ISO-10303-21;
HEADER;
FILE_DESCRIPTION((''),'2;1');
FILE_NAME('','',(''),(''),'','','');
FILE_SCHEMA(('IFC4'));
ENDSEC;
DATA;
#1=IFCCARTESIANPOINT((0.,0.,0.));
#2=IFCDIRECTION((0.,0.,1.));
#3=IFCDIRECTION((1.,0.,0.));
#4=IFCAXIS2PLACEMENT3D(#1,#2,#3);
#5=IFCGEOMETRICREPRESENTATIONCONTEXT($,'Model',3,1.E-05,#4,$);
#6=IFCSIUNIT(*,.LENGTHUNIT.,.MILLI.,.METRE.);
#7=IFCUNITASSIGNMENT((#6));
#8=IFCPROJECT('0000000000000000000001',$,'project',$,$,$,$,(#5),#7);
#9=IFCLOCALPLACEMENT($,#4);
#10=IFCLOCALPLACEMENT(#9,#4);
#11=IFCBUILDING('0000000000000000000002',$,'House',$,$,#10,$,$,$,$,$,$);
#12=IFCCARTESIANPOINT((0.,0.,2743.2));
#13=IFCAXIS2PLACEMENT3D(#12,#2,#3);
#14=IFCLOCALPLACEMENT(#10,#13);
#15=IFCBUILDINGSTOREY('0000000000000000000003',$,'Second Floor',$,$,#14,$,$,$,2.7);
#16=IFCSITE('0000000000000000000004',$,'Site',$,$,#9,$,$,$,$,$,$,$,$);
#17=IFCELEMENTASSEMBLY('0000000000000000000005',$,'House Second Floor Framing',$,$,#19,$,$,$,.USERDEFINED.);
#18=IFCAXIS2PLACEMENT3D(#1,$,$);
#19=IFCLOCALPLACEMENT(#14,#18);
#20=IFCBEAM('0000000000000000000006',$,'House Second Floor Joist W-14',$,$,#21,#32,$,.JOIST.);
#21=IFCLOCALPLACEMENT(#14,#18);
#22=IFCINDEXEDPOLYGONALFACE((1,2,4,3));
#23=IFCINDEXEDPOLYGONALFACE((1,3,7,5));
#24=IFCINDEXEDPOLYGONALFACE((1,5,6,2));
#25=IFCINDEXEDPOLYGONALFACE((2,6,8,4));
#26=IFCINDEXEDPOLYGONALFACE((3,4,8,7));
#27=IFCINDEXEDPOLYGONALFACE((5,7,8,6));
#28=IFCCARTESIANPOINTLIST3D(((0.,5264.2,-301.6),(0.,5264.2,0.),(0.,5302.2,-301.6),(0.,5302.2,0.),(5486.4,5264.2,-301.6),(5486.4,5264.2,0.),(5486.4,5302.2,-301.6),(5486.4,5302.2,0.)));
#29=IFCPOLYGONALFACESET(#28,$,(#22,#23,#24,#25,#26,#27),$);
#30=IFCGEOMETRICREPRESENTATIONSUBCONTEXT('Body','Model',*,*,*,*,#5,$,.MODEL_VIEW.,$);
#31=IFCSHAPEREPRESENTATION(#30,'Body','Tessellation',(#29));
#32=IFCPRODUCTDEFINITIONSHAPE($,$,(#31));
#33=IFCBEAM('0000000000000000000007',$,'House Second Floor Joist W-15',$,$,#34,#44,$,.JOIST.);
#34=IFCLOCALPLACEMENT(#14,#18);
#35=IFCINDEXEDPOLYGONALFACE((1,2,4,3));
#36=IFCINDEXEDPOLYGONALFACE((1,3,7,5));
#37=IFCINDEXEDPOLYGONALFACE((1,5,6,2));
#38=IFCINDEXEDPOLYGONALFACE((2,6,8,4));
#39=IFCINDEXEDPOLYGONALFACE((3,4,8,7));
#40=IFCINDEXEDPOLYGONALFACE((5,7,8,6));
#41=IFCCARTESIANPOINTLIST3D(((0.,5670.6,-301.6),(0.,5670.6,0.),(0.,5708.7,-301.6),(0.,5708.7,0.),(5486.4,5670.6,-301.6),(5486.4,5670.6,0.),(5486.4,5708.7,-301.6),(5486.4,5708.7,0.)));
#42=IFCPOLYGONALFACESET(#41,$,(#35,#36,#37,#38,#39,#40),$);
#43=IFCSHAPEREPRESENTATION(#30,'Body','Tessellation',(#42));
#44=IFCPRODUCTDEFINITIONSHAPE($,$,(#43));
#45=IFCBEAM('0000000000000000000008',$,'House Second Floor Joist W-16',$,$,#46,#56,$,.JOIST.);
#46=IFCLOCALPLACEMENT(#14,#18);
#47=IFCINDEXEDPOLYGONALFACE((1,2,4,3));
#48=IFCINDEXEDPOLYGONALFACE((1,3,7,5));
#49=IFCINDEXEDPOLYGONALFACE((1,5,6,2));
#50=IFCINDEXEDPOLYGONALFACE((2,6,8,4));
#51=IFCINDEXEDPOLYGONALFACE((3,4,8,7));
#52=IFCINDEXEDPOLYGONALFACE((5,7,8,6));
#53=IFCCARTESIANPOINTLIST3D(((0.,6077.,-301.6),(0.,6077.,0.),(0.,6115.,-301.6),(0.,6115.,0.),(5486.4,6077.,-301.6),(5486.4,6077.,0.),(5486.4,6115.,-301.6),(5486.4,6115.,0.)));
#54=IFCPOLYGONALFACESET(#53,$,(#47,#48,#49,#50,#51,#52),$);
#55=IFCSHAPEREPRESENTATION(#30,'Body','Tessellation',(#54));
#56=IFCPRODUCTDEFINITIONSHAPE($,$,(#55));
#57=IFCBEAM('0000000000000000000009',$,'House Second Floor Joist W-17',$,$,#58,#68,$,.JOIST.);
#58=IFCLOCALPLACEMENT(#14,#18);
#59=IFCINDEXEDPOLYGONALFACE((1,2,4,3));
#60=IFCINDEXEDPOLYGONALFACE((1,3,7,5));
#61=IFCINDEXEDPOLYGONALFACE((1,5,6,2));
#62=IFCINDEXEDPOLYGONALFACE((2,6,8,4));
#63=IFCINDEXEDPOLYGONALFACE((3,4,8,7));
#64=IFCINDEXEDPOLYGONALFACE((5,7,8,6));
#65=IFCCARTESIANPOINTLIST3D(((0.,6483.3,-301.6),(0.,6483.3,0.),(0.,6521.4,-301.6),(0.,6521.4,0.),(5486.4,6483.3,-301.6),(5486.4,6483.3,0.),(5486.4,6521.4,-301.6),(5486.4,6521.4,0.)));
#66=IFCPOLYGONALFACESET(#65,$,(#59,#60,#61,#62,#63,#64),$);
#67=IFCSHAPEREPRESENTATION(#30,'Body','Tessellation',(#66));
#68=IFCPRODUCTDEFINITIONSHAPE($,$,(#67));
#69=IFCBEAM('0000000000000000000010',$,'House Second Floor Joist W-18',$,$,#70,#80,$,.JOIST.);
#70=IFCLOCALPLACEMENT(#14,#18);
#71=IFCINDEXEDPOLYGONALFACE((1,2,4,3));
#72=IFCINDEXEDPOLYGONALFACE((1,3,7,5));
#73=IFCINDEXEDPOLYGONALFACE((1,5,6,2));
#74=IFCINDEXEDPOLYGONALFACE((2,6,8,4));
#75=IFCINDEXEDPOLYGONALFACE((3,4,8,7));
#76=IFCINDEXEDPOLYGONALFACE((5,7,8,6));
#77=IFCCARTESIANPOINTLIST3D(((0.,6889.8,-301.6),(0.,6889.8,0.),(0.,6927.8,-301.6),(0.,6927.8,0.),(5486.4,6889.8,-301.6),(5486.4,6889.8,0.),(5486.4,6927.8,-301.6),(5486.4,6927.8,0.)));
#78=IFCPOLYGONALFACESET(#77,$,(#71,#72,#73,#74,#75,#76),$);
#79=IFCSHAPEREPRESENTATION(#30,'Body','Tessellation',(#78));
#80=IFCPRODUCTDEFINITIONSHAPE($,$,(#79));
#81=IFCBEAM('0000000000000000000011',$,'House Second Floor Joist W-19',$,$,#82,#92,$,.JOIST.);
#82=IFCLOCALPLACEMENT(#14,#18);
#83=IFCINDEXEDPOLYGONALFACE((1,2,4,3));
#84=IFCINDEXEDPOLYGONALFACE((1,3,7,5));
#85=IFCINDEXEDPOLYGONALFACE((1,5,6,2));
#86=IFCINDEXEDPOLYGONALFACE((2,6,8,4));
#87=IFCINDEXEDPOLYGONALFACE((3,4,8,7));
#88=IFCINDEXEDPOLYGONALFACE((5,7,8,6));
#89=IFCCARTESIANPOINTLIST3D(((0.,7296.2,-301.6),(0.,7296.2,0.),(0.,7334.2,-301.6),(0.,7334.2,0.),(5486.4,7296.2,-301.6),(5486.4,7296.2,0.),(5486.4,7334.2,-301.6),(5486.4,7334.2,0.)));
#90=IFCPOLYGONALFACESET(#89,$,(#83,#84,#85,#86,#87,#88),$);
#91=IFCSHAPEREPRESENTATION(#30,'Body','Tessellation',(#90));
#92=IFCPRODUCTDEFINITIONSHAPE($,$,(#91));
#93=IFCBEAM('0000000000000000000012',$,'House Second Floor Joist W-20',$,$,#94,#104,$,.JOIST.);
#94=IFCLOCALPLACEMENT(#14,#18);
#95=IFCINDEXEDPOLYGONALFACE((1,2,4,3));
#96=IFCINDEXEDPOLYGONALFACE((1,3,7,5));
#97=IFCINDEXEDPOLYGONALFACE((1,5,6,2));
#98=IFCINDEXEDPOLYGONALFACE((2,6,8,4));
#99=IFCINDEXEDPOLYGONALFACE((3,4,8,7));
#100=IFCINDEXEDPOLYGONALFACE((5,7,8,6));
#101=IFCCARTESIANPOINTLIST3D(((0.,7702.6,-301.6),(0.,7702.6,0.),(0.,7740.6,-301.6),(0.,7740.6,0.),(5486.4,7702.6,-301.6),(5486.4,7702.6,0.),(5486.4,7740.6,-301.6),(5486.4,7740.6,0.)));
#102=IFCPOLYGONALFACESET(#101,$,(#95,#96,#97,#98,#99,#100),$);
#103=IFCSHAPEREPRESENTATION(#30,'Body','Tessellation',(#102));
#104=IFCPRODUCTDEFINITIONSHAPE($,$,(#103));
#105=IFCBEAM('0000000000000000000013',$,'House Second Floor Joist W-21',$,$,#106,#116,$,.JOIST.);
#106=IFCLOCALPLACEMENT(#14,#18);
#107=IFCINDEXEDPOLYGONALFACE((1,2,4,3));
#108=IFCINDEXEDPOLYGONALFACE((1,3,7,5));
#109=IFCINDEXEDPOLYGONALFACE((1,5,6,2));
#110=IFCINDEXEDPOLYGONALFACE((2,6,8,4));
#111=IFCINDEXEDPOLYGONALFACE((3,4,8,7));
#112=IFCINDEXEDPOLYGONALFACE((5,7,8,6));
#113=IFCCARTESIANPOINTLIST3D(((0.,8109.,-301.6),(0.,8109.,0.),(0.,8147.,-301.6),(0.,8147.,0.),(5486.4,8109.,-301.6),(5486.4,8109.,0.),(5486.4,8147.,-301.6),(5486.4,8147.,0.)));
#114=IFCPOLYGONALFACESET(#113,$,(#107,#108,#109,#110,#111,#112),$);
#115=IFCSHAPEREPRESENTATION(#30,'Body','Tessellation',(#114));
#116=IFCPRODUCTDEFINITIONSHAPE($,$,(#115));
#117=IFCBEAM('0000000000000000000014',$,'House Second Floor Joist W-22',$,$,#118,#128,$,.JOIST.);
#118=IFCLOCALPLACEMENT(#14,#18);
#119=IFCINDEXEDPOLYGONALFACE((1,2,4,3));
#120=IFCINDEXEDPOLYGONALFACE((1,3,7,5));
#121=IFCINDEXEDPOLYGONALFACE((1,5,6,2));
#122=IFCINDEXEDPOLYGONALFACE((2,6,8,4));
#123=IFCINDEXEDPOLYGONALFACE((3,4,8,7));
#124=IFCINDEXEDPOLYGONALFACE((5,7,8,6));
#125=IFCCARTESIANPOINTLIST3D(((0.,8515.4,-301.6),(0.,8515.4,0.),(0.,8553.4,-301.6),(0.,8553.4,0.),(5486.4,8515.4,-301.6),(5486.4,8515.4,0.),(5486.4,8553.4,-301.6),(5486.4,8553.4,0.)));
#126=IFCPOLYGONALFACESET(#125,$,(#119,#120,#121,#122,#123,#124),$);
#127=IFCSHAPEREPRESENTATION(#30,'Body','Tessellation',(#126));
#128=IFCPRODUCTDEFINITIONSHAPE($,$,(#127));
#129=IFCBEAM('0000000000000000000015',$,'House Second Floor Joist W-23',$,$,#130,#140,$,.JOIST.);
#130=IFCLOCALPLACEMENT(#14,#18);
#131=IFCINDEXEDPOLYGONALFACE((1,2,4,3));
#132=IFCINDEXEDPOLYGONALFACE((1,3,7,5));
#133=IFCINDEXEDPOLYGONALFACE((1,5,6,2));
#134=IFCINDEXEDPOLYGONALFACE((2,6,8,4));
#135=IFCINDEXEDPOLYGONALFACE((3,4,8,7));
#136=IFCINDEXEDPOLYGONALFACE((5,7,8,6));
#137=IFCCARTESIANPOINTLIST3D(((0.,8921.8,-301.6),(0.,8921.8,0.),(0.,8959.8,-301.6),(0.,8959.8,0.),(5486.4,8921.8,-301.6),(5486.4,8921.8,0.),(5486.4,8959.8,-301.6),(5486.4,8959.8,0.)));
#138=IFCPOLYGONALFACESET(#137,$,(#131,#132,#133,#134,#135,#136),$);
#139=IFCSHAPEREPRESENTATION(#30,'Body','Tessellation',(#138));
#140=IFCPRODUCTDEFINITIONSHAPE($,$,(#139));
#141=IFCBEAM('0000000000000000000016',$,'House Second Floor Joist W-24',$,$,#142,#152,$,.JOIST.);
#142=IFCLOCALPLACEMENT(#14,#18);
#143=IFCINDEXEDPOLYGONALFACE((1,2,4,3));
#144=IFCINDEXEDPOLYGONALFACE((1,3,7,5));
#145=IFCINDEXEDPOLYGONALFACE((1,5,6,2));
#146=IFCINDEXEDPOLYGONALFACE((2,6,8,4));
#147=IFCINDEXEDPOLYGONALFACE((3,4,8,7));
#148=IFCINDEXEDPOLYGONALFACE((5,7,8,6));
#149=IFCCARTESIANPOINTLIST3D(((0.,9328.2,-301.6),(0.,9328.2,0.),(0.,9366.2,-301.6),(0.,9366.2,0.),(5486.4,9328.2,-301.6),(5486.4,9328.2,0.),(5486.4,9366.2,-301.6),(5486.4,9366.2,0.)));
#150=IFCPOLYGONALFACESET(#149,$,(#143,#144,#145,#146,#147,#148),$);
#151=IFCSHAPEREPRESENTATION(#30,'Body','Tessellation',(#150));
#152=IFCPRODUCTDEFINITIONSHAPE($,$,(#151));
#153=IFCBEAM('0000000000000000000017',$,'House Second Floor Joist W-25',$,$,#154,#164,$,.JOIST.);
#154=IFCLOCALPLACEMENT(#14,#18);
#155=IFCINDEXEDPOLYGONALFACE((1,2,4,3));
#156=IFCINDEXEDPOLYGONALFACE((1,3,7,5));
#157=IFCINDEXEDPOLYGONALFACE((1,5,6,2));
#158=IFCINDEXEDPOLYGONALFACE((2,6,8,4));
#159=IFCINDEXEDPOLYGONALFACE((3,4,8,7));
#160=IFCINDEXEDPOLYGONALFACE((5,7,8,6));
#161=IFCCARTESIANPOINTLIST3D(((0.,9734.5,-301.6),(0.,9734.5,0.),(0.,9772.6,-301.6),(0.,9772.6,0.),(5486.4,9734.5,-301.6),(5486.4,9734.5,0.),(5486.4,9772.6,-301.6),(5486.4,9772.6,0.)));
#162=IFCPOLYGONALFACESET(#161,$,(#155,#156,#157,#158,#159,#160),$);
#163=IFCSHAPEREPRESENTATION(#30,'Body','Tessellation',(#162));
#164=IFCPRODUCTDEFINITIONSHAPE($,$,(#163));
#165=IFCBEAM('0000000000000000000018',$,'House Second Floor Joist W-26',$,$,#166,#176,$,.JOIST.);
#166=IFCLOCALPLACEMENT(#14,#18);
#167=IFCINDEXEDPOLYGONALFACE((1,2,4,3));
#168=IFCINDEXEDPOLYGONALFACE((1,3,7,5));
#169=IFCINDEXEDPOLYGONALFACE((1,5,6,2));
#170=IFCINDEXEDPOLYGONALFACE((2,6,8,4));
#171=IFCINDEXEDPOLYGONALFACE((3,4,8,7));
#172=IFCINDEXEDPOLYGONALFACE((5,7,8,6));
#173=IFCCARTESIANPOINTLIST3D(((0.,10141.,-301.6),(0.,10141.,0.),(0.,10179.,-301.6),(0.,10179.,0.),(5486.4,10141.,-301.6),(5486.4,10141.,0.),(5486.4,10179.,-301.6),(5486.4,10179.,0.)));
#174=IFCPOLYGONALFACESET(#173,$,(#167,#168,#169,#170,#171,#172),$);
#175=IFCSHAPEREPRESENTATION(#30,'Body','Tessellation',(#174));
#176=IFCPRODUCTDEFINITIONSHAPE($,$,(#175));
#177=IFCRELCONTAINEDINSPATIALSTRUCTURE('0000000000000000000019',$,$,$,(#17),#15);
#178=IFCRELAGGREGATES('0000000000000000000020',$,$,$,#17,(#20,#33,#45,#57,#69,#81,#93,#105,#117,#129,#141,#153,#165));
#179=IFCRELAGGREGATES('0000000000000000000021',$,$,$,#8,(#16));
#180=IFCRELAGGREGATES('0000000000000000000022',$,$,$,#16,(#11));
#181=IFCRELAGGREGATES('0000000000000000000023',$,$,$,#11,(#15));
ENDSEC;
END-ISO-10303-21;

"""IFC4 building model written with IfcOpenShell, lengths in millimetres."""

from ifc_helpers import new_model, si_unit, frame, origin_with_axes, origin_2d, place, context, subcontext, project, spatial, rectangle, extrude, element, aggregate, save


model = new_model("IFC4")

# Units and contexts
model_context = context("Model", 3, precision=1e-05, world=origin_with_axes())
body_context = subcontext(model_context, "Body", "Model", "MODEL_VIEW")
ifc_project = project(units=[si_unit("LENGTHUNIT", "METRE", prefix="MILLI")], contexts=[model_context])

# Site, building, storey
site_placement = place(None, origin_with_axes())
site = spatial("IfcSite", under=ifc_project, at=site_placement, Name="Site")
building_placement = place(site_placement, origin_with_axes())
building = spatial("IfcBuilding", under=site, at=building_placement, Name="House")
storey_placement = place(building_placement, frame((0.0, 0.0, 2743.2), z_axis=(0.0, 0.0, 1.0), x_axis=(1.0, 0.0, 0.0)))
storey = spatial("IfcBuildingStorey", under=building, at=storey_placement, Name="Second Floor", Elevation=2.7)

# Element assembly, beams
assembly_1_placement = place(storey_placement, frame((0.0, 0.0, -2743.2), z_axis=(0.0, 0.0, 1.0), x_axis=(1.0, 0.0, 0.0)))
assembly_1 = element("IfcElementAssembly", 1, at=assembly_1_placement, inside=storey, Name="House Second Floor Framing", PredefinedType="USERDEFINED")
beam_1_placement = place(assembly_1_placement, frame((0.0, 5283.2, 2592.4), z_axis=(1.0, 0.0, 0.0), x_axis=(0.0, 1.0, 0.0)))
beam_1 = element("IfcBeam", 2, at=beam_1_placement, Name="House Second Floor Joist W-14", PredefinedType="JOIST", context=body_context, shape_type="SweptSolid", body=[
    extrude(rectangle(XDim=38.1, YDim=301.6, at=origin_2d()), origin_with_axes(), (0.0, 0.0, 1.0), 5486.4),
])
beam_2_placement = place(assembly_1_placement, frame((0.0, 5689.6, 2592.4), z_axis=(1.0, 0.0, 0.0), x_axis=(0.0, 1.0, 0.0)))
beam_2 = element("IfcBeam", 3, at=beam_2_placement, Name="House Second Floor Joist W-15", PredefinedType="JOIST", context=body_context, shape_type="SweptSolid", body=[
    extrude(rectangle(XDim=38.1, YDim=301.6, at=origin_2d()), origin_with_axes(), (0.0, 0.0, 1.0), 5486.4),
])
beam_3_placement = place(assembly_1_placement, frame((0.0, 6096.0, 2592.4), z_axis=(1.0, 0.0, 0.0), x_axis=(0.0, 1.0, 0.0)))
beam_3 = element("IfcBeam", 4, at=beam_3_placement, Name="House Second Floor Joist W-16", PredefinedType="JOIST", context=body_context, shape_type="SweptSolid", body=[
    extrude(rectangle(XDim=38.1, YDim=301.6, at=origin_2d()), origin_with_axes(), (0.0, 0.0, 1.0), 5486.4),
])
beam_4_placement = place(assembly_1_placement, frame((0.0, 6502.4, 2592.4), z_axis=(1.0, 0.0, 0.0), x_axis=(0.0, 1.0, 0.0)))
beam_4 = element("IfcBeam", 5, at=beam_4_placement, Name="House Second Floor Joist W-17", PredefinedType="JOIST", context=body_context, shape_type="SweptSolid", body=[
    extrude(rectangle(XDim=38.1, YDim=301.6, at=origin_2d()), origin_with_axes(), (0.0, 0.0, 1.0), 5486.4),
])
beam_5_placement = place(assembly_1_placement, frame((0.0, 6908.8, 2592.4), z_axis=(1.0, 0.0, 0.0), x_axis=(0.0, 1.0, 0.0)))
beam_5 = element("IfcBeam", 6, at=beam_5_placement, Name="House Second Floor Joist W-18", PredefinedType="JOIST", context=body_context, shape_type="SweptSolid", body=[
    extrude(rectangle(XDim=38.1, YDim=301.6, at=origin_2d()), origin_with_axes(), (0.0, 0.0, 1.0), 5486.4),
])
beam_6_placement = place(assembly_1_placement, frame((0.0, 7315.2, 2592.4), z_axis=(1.0, 0.0, 0.0), x_axis=(0.0, 1.0, 0.0)))
beam_6 = element("IfcBeam", 7, at=beam_6_placement, Name="House Second Floor Joist W-19", PredefinedType="JOIST", context=body_context, shape_type="SweptSolid", body=[
    extrude(rectangle(XDim=38.1, YDim=301.6, at=origin_2d()), origin_with_axes(), (0.0, 0.0, 1.0), 5486.4),
])
beam_7_placement = place(assembly_1_placement, frame((0.0, 7721.6, 2592.4), z_axis=(1.0, 0.0, 0.0), x_axis=(0.0, 1.0, 0.0)))
beam_7 = element("IfcBeam", 8, at=beam_7_placement, Name="House Second Floor Joist W-20", PredefinedType="JOIST", context=body_context, shape_type="SweptSolid", body=[
    extrude(rectangle(XDim=38.1, YDim=301.6, at=origin_2d()), origin_with_axes(), (0.0, 0.0, 1.0), 5486.4),
])
beam_8_placement = place(assembly_1_placement, frame((0.0, 8128.0, 2592.4), z_axis=(1.0, 0.0, 0.0), x_axis=(0.0, 1.0, 0.0)))
beam_8 = element("IfcBeam", 9, at=beam_8_placement, Name="House Second Floor Joist W-21", PredefinedType="JOIST", context=body_context, shape_type="SweptSolid", body=[
    extrude(rectangle(XDim=38.1, YDim=301.6, at=origin_2d()), origin_with_axes(), (0.0, 0.0, 1.0), 5486.4),
])
beam_9_placement = place(assembly_1_placement, frame((0.0, 8534.4, 2592.4), z_axis=(1.0, 0.0, 0.0), x_axis=(0.0, 1.0, 0.0)))
beam_9 = element("IfcBeam", 10, at=beam_9_placement, Name="House Second Floor Joist W-22", PredefinedType="JOIST", context=body_context, shape_type="SweptSolid", body=[
    extrude(rectangle(XDim=38.1, YDim=301.6, at=origin_2d()), origin_with_axes(), (0.0, 0.0, 1.0), 5486.4),
])
beam_10_placement = place(assembly_1_placement, frame((0.0, 8940.8, 2592.4), z_axis=(1.0, 0.0, 0.0), x_axis=(0.0, 1.0, 0.0)))
beam_10 = element("IfcBeam", 11, at=beam_10_placement, Name="House Second Floor Joist W-23", PredefinedType="JOIST", context=body_context, shape_type="SweptSolid", body=[
    extrude(rectangle(XDim=38.1, YDim=301.6, at=origin_2d()), origin_with_axes(), (0.0, 0.0, 1.0), 5486.4),
])
beam_11_placement = place(assembly_1_placement, frame((0.0, 9347.2, 2592.4), z_axis=(1.0, 0.0, 0.0), x_axis=(0.0, 1.0, 0.0)))
beam_11 = element("IfcBeam", 12, at=beam_11_placement, Name="House Second Floor Joist W-24", PredefinedType="JOIST", context=body_context, shape_type="SweptSolid", body=[
    extrude(rectangle(XDim=38.1, YDim=301.6, at=origin_2d()), origin_with_axes(), (0.0, 0.0, 1.0), 5486.4),
])
beam_12_placement = place(assembly_1_placement, frame((0.0, 9753.6, 2592.4), z_axis=(1.0, 0.0, 0.0), x_axis=(0.0, 1.0, 0.0)))
beam_12 = element("IfcBeam", 13, at=beam_12_placement, Name="House Second Floor Joist W-25", PredefinedType="JOIST", context=body_context, shape_type="SweptSolid", body=[
    extrude(rectangle(XDim=38.1, YDim=301.6, at=origin_2d()), origin_with_axes(), (0.0, 0.0, 1.0), 5486.4),
])
beam_13_placement = place(assembly_1_placement, frame((0.0, 10160.0, 2592.4), z_axis=(1.0, 0.0, 0.0), x_axis=(0.0, 1.0, 0.0)))
beam_13 = element("IfcBeam", 14, at=beam_13_placement, Name="House Second Floor Joist W-26", PredefinedType="JOIST", context=body_context, shape_type="SweptSolid", body=[
    extrude(rectangle(XDim=38.1, YDim=301.6, at=origin_2d()), origin_with_axes(), (0.0, 0.0, 1.0), 5486.4),
])
aggregate(assembly_1, [beam_1, beam_2, beam_3, beam_4, beam_5, beam_6, beam_7, beam_8, beam_9, beam_10, beam_11, beam_12, beam_13])

save(model, "model.ifc")
